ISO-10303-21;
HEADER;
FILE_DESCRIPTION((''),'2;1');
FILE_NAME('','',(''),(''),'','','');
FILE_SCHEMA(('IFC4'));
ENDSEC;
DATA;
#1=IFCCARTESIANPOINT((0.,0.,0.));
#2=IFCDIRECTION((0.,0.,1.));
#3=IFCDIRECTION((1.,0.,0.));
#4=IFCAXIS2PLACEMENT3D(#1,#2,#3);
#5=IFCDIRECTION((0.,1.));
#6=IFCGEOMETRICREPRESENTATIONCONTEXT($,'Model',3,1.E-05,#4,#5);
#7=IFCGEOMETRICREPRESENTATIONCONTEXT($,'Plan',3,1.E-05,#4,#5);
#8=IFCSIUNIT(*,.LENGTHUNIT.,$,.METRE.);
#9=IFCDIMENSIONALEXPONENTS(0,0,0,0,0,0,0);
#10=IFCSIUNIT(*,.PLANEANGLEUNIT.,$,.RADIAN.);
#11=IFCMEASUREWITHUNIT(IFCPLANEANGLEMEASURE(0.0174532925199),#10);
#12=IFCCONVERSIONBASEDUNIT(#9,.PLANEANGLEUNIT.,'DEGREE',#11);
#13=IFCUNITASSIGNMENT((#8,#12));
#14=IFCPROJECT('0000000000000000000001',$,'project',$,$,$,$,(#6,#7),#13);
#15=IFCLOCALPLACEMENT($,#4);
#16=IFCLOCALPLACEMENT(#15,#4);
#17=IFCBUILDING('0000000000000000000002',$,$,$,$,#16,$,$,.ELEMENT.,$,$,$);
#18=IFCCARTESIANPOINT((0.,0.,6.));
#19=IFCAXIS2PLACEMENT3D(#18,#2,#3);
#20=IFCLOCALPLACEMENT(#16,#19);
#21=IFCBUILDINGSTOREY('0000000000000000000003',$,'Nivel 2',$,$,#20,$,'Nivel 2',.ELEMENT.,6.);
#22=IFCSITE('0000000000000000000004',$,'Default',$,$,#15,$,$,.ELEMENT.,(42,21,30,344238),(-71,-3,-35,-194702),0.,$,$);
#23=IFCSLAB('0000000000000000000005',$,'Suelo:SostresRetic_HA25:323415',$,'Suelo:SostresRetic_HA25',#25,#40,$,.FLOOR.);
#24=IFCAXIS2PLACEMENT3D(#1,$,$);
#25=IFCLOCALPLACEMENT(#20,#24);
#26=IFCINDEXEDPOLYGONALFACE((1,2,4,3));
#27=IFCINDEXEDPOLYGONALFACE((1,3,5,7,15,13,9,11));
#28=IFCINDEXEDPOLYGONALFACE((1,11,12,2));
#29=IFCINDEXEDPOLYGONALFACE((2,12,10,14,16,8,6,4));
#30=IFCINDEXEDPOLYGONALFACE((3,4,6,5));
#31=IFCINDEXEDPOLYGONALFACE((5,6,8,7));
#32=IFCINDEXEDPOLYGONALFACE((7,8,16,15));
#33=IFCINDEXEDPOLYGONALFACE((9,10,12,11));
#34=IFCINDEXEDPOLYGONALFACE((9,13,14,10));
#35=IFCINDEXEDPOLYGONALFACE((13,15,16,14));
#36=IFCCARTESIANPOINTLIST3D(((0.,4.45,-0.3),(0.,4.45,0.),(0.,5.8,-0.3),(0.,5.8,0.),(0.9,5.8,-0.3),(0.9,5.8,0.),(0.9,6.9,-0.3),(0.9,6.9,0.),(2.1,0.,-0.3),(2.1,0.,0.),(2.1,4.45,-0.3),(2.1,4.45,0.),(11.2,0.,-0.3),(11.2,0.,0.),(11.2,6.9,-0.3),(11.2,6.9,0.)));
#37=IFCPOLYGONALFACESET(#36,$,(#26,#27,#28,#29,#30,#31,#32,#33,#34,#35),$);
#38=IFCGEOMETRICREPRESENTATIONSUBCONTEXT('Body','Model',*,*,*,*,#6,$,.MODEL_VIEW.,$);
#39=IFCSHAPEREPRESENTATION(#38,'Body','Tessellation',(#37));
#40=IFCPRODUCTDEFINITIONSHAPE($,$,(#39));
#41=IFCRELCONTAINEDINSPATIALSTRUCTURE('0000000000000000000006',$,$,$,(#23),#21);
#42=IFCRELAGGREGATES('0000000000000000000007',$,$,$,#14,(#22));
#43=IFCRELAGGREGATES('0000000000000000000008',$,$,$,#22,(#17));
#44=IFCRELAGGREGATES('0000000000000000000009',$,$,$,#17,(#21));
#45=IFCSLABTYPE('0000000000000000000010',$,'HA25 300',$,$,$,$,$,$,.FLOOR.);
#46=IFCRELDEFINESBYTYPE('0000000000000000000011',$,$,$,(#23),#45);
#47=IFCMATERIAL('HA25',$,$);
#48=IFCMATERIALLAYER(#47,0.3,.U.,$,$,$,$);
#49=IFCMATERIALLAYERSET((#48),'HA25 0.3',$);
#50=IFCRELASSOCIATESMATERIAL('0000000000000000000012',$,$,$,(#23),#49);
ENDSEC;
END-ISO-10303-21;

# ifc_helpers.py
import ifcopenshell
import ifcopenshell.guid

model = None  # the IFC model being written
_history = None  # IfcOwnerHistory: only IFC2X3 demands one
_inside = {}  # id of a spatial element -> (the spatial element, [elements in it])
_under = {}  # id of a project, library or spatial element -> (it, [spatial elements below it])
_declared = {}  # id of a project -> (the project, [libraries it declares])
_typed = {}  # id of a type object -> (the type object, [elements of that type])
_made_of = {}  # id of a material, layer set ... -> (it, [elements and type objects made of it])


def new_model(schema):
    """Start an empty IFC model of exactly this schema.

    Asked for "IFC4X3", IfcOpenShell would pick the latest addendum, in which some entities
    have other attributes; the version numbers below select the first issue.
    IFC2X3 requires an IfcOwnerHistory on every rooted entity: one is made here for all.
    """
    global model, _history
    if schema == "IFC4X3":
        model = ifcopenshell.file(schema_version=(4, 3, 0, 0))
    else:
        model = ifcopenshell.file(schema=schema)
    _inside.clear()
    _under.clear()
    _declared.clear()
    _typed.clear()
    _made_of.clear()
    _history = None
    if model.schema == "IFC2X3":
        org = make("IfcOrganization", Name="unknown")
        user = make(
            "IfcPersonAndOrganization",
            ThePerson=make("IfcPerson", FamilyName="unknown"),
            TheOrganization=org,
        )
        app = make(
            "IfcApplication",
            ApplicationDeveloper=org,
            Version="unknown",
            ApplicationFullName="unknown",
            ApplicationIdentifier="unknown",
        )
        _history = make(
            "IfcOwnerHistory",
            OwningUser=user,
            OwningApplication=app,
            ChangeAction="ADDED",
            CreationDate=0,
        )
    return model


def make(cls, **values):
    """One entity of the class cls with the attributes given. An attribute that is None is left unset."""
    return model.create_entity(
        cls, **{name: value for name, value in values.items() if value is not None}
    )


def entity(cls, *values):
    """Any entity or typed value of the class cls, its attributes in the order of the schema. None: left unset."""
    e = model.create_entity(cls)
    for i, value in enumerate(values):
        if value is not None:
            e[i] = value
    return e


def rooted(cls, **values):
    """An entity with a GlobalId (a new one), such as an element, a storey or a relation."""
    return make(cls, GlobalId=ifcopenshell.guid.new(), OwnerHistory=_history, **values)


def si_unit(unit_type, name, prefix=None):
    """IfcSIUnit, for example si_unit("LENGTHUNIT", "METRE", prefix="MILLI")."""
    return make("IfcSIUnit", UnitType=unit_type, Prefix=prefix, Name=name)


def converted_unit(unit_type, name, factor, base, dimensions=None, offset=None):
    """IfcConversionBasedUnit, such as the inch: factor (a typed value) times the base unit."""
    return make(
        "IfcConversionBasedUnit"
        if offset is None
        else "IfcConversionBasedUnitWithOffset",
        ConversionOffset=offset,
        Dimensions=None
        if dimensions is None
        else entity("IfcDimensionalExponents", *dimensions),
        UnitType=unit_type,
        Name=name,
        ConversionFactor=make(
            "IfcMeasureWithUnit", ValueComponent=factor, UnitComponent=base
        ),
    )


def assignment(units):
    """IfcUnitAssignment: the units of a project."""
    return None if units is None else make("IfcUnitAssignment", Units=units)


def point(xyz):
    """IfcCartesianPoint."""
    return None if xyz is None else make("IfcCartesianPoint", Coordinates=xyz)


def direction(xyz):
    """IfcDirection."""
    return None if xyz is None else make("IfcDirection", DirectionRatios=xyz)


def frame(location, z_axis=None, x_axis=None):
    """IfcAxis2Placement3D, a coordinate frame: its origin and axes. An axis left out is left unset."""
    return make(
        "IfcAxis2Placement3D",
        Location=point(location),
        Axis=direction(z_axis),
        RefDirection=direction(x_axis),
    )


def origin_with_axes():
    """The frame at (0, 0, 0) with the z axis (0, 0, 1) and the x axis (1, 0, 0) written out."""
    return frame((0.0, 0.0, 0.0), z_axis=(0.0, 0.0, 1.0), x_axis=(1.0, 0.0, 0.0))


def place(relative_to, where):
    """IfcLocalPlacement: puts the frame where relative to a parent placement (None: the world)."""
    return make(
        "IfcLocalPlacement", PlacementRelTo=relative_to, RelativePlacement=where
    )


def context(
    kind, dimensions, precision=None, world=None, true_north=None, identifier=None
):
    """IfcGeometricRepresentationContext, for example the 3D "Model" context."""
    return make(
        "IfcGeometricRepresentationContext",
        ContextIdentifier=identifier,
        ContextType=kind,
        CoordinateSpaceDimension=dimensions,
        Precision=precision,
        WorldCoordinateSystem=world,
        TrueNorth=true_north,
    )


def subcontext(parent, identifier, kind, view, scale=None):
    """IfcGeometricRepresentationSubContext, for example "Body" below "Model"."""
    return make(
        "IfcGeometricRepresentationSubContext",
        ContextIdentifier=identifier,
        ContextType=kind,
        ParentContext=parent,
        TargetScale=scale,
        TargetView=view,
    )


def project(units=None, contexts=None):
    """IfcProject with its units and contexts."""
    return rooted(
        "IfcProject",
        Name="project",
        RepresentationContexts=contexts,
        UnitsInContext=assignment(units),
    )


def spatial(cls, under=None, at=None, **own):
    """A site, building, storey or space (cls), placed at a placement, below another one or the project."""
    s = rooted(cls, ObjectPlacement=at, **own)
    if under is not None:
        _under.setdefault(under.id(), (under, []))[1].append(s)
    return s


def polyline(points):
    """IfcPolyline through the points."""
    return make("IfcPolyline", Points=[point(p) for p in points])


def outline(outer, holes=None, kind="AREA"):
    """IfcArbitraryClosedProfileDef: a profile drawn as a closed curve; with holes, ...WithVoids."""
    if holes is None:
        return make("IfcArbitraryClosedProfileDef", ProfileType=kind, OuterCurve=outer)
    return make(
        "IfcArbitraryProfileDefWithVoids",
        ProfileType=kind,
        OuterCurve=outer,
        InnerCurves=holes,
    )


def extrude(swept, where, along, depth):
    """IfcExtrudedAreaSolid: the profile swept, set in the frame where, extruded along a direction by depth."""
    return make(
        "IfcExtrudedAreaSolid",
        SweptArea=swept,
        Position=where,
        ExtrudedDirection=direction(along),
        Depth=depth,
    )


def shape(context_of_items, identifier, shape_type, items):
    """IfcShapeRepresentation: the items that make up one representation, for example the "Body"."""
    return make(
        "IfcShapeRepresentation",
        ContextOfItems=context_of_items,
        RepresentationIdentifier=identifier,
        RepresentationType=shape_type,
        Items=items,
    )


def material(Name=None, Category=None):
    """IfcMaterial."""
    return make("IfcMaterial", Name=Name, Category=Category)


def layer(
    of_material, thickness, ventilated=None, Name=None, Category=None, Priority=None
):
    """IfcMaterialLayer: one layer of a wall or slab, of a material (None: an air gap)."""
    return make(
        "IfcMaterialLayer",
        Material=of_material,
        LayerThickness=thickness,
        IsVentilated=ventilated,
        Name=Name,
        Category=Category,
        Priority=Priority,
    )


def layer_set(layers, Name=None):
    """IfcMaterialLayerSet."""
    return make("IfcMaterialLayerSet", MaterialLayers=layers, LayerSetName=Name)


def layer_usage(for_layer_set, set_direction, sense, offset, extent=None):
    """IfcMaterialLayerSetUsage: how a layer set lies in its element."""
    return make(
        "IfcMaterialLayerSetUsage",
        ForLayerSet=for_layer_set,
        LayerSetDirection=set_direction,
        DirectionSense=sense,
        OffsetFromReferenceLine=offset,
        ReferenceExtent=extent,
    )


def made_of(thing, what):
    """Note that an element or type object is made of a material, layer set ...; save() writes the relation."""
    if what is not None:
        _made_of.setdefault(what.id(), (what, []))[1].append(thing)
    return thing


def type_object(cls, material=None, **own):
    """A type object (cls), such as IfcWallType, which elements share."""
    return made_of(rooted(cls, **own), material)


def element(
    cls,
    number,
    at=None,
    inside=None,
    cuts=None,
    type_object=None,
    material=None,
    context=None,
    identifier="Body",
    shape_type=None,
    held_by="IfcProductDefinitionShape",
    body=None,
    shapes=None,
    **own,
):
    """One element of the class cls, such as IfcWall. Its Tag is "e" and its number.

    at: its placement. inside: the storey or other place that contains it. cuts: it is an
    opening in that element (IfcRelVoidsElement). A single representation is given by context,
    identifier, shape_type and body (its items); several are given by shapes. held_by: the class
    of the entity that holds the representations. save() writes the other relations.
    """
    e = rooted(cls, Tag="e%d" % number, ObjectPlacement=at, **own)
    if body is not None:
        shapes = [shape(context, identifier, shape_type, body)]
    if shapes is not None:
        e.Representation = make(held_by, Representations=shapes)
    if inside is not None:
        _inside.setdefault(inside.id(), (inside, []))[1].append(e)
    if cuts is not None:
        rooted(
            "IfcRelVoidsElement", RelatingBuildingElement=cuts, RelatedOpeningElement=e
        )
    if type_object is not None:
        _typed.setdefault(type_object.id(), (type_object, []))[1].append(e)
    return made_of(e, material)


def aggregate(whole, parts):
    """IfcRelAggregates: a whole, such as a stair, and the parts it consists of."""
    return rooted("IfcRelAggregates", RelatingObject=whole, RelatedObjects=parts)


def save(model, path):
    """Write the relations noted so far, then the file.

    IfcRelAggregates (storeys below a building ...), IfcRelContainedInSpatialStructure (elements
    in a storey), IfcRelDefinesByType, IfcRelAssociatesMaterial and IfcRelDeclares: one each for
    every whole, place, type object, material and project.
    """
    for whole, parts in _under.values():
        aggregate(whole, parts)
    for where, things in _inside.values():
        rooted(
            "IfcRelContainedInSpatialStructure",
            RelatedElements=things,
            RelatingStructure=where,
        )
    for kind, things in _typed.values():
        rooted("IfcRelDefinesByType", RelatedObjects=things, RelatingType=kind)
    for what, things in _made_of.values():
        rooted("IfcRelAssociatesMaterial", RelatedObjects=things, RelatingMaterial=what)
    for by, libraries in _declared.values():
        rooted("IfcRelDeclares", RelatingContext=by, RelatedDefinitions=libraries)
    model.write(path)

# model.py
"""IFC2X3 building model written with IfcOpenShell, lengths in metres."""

from ifc_helpers import new_model, entity, si_unit, converted_unit, direction, frame, origin_with_axes, place, context, subcontext, project, spatial, polyline, outline, extrude, material, layer, layer_set, layer_usage, type_object, element, save


model = new_model("IFC2X3")

# Units and contexts
model_context = context("Model", 3, precision=1e-05, world=origin_with_axes(), true_north=direction((0.0, 1.0)))
plan_context = context("Plan", 3, precision=1e-05, world=origin_with_axes(), true_north=direction((0.0, 1.0)))
body_context = subcontext(model_context, "Body", "Model", "MODEL_VIEW")
ifc_project = project(units=[si_unit("LENGTHUNIT", "METRE"), converted_unit("PLANEANGLEUNIT", "DEGREE", entity("IfcPlaneAngleMeasure", 0.0174532925199), si_unit("PLANEANGLEUNIT", "RADIAN"), dimensions=[0, 0, 0, 0, 0, 0, 0])], contexts=[model_context, plan_context])

# Site, building, storey
site_placement = place(None, origin_with_axes())
site = spatial("IfcSite", under=ifc_project, at=site_placement, Name="Default", CompositionType="ELEMENT", RefLatitude=(42, 21, 30, 344238), RefLongitude=(-71, -3, -35, -194702), RefElevation=0.0)
building_placement = place(site_placement, origin_with_axes())
building = spatial("IfcBuilding", under=site, at=building_placement, CompositionType="ELEMENT")
storey_placement = place(building_placement, frame((0.0, 0.0, 6.0), z_axis=(0.0, 0.0, 1.0), x_axis=(1.0, 0.0, 0.0)))
storey = spatial("IfcBuildingStorey", under=building, at=storey_placement, Name="Nivel 2", LongName="Nivel 2", CompositionType="ELEMENT", Elevation=6.0)

# Slab
ifc_material = material(Name="HA25")
ifc_layer = layer(ifc_material, 0.3, ventilated="UNKNOWN")
ifc_layer_set = layer_set([ifc_layer], Name="HA25 0.3")
ifc_layer_usage = layer_usage(ifc_layer_set, "AXIS3", "NEGATIVE", 0.3)
slab_type = type_object("IfcSlabType", Name="HA25 300", PredefinedType="FLOOR")
slab_placement = place(storey_placement, frame((0.0, 4.45, 0.0), z_axis=(0.0, 0.0, 1.0), x_axis=(1.0, 0.0, 0.0)))
element("IfcSlab", 1, at=slab_placement, inside=storey, type_object=slab_type, material=ifc_layer_usage, Name="Suelo:SostresRetic_HA25:323415", ObjectType="Suelo:SostresRetic_HA25", PredefinedType="FLOOR", context=body_context, shape_type="SweptSolid", body=[
    extrude(outline(polyline([(0.0, 0.0), (2.1, 0.0), (2.1, -4.45), (11.2, -4.45), (11.2, 2.45), (0.9, 2.45), (0.9, 1.35), (0.0, 1.35), (0.0, 0.0)])), frame((0.0, 0.0, -0.3), z_axis=(0.0, 0.0, 1.0), x_axis=(1.0, 0.0, 0.0)), (0.0, 0.0, 1.0), 0.3),
])

save(model, "model.ifc")
